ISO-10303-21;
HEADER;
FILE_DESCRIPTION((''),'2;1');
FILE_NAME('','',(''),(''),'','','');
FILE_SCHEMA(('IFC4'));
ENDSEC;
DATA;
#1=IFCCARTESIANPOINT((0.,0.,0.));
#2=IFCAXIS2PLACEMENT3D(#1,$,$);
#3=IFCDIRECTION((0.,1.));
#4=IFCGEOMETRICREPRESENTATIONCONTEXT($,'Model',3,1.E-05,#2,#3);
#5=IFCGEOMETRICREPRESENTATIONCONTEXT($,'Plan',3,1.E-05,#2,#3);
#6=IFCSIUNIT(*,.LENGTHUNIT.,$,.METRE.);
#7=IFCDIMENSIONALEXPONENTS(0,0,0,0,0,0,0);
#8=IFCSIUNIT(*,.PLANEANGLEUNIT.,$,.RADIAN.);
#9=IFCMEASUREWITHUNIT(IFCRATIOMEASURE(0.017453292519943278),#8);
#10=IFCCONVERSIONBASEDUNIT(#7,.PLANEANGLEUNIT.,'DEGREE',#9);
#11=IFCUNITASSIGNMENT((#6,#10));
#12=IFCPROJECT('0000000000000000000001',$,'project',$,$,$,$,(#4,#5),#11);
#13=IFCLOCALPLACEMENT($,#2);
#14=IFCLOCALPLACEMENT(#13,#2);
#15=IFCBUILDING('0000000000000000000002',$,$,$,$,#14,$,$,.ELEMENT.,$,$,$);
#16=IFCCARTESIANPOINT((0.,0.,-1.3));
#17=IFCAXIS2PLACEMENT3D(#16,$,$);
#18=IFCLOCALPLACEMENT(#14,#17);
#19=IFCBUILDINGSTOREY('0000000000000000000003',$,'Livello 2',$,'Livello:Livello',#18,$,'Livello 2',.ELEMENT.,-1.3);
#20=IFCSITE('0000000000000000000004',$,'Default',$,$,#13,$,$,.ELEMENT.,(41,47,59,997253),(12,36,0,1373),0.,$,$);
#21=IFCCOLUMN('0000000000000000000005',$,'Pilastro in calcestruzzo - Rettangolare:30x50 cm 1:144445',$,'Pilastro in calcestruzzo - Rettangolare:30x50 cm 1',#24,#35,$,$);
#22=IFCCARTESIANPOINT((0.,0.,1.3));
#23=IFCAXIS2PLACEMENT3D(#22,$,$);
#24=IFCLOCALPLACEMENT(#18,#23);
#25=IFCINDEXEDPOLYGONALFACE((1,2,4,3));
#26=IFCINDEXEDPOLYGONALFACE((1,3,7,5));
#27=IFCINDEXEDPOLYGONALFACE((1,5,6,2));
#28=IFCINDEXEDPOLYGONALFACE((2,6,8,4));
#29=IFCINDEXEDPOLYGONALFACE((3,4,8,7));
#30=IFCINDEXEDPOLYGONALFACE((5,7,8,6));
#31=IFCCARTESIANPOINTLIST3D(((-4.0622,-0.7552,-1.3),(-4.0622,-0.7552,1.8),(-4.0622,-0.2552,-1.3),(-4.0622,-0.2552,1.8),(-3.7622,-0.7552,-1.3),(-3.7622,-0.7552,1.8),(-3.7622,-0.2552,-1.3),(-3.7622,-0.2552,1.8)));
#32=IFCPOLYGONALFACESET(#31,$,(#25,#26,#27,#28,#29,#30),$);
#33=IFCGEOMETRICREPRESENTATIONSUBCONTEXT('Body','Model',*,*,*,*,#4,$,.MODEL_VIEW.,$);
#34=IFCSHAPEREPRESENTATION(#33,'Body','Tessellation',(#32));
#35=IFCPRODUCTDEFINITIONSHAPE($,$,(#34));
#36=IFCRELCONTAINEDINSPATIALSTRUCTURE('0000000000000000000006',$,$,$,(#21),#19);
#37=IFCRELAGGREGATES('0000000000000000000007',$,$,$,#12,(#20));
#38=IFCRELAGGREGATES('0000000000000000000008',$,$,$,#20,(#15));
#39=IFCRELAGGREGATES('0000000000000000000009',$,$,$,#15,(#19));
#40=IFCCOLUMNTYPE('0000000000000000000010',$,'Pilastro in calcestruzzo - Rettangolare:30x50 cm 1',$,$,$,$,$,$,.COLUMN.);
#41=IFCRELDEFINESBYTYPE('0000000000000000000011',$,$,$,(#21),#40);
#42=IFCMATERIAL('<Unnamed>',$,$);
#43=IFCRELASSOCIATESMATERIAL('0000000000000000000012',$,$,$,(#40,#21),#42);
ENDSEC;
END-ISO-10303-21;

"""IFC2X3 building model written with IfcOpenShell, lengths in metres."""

from ifc_helpers import new_model, entity, si_unit, converted_unit, direction, frame, frame_2d, origin, place, context, subcontext, project, spatial, rectangle, extrude, source, transform, mapped, material, type_object, type_shapes, element, save


model = new_model("IFC2X3")

# Units and contexts
model_context = context("Model", 3, precision=1e-05, world=origin(), true_north=direction((0.0, 1.0)))
plan_context = context("Plan", 3, precision=1e-05, world=origin(), true_north=direction((0.0, 1.0)))
body_context = subcontext(model_context, "Body", "Model", "MODEL_VIEW")
ifc_project = project(units=[si_unit("LENGTHUNIT", "METRE"), converted_unit("PLANEANGLEUNIT", "DEGREE", entity("IfcRatioMeasure", 0.017453292519943278), si_unit("PLANEANGLEUNIT", "RADIAN"), dimensions=[0, 0, 0, 0, 0, 0, 0])], contexts=[model_context, plan_context])

# Site, building, storey
site_placement = place(None, origin())
site = spatial("IfcSite", under=ifc_project, at=site_placement, Name="Default", CompositionType="ELEMENT", RefLatitude=(41, 47, 59, 997253), RefLongitude=(12, 36, 0, 1373), RefElevation=0.0)
building_placement = place(site_placement, origin())
building = spatial("IfcBuilding", under=site, at=building_placement, CompositionType="ELEMENT")
storey_placement = place(building_placement, frame((0.0, 0.0, -1.3)))
storey = spatial("IfcBuildingStorey", under=building, at=storey_placement, Name="Livello 2", ObjectType="Livello:Livello", LongName="Livello 2", CompositionType="ELEMENT", Elevation=-1.3)

# Column
ifc_material_1 = material(Name="<Unnamed>")
column_type_1 = type_object("IfcColumnType", Name="Pilastro in calcestruzzo - Rettangolare:30x50 cm 1", PredefinedType="COLUMN", material=ifc_material_1)
shared_shape_1 = source(origin(), body_context, "Body", "SweptSolid", [
    extrude(rectangle(XDim=0.5, YDim=0.3, at=frame_2d((0.0, 0.0), x_axis=(1.0, 0.0))), frame((-3.9122, -0.5052, -1.3), z_axis=(0.0, 0.0, 1.0), x_axis=(0.0, -1.0, 0.0)), (0.0, 0.0, 1.0), 3.1),
])
type_shapes(column_type_1, [shared_shape_1])
column_1_placement = place(storey_placement, frame((0.0, 0.0, 1.3)))
element("IfcColumn", 1, at=column_1_placement, inside=storey, type_object=column_type_1, material=ifc_material_1, Name="Pilastro in calcestruzzo - Rettangolare:30x50 cm 1:144445", ObjectType="Pilastro in calcestruzzo - Rettangolare:30x50 cm 1", context=body_context, shape_type="MappedRepresentation", body=[
    mapped(shared_shape_1, transform((0.0, 0.0, 0.0), scale=1.0)),
])

save(model, "model.ifc")
